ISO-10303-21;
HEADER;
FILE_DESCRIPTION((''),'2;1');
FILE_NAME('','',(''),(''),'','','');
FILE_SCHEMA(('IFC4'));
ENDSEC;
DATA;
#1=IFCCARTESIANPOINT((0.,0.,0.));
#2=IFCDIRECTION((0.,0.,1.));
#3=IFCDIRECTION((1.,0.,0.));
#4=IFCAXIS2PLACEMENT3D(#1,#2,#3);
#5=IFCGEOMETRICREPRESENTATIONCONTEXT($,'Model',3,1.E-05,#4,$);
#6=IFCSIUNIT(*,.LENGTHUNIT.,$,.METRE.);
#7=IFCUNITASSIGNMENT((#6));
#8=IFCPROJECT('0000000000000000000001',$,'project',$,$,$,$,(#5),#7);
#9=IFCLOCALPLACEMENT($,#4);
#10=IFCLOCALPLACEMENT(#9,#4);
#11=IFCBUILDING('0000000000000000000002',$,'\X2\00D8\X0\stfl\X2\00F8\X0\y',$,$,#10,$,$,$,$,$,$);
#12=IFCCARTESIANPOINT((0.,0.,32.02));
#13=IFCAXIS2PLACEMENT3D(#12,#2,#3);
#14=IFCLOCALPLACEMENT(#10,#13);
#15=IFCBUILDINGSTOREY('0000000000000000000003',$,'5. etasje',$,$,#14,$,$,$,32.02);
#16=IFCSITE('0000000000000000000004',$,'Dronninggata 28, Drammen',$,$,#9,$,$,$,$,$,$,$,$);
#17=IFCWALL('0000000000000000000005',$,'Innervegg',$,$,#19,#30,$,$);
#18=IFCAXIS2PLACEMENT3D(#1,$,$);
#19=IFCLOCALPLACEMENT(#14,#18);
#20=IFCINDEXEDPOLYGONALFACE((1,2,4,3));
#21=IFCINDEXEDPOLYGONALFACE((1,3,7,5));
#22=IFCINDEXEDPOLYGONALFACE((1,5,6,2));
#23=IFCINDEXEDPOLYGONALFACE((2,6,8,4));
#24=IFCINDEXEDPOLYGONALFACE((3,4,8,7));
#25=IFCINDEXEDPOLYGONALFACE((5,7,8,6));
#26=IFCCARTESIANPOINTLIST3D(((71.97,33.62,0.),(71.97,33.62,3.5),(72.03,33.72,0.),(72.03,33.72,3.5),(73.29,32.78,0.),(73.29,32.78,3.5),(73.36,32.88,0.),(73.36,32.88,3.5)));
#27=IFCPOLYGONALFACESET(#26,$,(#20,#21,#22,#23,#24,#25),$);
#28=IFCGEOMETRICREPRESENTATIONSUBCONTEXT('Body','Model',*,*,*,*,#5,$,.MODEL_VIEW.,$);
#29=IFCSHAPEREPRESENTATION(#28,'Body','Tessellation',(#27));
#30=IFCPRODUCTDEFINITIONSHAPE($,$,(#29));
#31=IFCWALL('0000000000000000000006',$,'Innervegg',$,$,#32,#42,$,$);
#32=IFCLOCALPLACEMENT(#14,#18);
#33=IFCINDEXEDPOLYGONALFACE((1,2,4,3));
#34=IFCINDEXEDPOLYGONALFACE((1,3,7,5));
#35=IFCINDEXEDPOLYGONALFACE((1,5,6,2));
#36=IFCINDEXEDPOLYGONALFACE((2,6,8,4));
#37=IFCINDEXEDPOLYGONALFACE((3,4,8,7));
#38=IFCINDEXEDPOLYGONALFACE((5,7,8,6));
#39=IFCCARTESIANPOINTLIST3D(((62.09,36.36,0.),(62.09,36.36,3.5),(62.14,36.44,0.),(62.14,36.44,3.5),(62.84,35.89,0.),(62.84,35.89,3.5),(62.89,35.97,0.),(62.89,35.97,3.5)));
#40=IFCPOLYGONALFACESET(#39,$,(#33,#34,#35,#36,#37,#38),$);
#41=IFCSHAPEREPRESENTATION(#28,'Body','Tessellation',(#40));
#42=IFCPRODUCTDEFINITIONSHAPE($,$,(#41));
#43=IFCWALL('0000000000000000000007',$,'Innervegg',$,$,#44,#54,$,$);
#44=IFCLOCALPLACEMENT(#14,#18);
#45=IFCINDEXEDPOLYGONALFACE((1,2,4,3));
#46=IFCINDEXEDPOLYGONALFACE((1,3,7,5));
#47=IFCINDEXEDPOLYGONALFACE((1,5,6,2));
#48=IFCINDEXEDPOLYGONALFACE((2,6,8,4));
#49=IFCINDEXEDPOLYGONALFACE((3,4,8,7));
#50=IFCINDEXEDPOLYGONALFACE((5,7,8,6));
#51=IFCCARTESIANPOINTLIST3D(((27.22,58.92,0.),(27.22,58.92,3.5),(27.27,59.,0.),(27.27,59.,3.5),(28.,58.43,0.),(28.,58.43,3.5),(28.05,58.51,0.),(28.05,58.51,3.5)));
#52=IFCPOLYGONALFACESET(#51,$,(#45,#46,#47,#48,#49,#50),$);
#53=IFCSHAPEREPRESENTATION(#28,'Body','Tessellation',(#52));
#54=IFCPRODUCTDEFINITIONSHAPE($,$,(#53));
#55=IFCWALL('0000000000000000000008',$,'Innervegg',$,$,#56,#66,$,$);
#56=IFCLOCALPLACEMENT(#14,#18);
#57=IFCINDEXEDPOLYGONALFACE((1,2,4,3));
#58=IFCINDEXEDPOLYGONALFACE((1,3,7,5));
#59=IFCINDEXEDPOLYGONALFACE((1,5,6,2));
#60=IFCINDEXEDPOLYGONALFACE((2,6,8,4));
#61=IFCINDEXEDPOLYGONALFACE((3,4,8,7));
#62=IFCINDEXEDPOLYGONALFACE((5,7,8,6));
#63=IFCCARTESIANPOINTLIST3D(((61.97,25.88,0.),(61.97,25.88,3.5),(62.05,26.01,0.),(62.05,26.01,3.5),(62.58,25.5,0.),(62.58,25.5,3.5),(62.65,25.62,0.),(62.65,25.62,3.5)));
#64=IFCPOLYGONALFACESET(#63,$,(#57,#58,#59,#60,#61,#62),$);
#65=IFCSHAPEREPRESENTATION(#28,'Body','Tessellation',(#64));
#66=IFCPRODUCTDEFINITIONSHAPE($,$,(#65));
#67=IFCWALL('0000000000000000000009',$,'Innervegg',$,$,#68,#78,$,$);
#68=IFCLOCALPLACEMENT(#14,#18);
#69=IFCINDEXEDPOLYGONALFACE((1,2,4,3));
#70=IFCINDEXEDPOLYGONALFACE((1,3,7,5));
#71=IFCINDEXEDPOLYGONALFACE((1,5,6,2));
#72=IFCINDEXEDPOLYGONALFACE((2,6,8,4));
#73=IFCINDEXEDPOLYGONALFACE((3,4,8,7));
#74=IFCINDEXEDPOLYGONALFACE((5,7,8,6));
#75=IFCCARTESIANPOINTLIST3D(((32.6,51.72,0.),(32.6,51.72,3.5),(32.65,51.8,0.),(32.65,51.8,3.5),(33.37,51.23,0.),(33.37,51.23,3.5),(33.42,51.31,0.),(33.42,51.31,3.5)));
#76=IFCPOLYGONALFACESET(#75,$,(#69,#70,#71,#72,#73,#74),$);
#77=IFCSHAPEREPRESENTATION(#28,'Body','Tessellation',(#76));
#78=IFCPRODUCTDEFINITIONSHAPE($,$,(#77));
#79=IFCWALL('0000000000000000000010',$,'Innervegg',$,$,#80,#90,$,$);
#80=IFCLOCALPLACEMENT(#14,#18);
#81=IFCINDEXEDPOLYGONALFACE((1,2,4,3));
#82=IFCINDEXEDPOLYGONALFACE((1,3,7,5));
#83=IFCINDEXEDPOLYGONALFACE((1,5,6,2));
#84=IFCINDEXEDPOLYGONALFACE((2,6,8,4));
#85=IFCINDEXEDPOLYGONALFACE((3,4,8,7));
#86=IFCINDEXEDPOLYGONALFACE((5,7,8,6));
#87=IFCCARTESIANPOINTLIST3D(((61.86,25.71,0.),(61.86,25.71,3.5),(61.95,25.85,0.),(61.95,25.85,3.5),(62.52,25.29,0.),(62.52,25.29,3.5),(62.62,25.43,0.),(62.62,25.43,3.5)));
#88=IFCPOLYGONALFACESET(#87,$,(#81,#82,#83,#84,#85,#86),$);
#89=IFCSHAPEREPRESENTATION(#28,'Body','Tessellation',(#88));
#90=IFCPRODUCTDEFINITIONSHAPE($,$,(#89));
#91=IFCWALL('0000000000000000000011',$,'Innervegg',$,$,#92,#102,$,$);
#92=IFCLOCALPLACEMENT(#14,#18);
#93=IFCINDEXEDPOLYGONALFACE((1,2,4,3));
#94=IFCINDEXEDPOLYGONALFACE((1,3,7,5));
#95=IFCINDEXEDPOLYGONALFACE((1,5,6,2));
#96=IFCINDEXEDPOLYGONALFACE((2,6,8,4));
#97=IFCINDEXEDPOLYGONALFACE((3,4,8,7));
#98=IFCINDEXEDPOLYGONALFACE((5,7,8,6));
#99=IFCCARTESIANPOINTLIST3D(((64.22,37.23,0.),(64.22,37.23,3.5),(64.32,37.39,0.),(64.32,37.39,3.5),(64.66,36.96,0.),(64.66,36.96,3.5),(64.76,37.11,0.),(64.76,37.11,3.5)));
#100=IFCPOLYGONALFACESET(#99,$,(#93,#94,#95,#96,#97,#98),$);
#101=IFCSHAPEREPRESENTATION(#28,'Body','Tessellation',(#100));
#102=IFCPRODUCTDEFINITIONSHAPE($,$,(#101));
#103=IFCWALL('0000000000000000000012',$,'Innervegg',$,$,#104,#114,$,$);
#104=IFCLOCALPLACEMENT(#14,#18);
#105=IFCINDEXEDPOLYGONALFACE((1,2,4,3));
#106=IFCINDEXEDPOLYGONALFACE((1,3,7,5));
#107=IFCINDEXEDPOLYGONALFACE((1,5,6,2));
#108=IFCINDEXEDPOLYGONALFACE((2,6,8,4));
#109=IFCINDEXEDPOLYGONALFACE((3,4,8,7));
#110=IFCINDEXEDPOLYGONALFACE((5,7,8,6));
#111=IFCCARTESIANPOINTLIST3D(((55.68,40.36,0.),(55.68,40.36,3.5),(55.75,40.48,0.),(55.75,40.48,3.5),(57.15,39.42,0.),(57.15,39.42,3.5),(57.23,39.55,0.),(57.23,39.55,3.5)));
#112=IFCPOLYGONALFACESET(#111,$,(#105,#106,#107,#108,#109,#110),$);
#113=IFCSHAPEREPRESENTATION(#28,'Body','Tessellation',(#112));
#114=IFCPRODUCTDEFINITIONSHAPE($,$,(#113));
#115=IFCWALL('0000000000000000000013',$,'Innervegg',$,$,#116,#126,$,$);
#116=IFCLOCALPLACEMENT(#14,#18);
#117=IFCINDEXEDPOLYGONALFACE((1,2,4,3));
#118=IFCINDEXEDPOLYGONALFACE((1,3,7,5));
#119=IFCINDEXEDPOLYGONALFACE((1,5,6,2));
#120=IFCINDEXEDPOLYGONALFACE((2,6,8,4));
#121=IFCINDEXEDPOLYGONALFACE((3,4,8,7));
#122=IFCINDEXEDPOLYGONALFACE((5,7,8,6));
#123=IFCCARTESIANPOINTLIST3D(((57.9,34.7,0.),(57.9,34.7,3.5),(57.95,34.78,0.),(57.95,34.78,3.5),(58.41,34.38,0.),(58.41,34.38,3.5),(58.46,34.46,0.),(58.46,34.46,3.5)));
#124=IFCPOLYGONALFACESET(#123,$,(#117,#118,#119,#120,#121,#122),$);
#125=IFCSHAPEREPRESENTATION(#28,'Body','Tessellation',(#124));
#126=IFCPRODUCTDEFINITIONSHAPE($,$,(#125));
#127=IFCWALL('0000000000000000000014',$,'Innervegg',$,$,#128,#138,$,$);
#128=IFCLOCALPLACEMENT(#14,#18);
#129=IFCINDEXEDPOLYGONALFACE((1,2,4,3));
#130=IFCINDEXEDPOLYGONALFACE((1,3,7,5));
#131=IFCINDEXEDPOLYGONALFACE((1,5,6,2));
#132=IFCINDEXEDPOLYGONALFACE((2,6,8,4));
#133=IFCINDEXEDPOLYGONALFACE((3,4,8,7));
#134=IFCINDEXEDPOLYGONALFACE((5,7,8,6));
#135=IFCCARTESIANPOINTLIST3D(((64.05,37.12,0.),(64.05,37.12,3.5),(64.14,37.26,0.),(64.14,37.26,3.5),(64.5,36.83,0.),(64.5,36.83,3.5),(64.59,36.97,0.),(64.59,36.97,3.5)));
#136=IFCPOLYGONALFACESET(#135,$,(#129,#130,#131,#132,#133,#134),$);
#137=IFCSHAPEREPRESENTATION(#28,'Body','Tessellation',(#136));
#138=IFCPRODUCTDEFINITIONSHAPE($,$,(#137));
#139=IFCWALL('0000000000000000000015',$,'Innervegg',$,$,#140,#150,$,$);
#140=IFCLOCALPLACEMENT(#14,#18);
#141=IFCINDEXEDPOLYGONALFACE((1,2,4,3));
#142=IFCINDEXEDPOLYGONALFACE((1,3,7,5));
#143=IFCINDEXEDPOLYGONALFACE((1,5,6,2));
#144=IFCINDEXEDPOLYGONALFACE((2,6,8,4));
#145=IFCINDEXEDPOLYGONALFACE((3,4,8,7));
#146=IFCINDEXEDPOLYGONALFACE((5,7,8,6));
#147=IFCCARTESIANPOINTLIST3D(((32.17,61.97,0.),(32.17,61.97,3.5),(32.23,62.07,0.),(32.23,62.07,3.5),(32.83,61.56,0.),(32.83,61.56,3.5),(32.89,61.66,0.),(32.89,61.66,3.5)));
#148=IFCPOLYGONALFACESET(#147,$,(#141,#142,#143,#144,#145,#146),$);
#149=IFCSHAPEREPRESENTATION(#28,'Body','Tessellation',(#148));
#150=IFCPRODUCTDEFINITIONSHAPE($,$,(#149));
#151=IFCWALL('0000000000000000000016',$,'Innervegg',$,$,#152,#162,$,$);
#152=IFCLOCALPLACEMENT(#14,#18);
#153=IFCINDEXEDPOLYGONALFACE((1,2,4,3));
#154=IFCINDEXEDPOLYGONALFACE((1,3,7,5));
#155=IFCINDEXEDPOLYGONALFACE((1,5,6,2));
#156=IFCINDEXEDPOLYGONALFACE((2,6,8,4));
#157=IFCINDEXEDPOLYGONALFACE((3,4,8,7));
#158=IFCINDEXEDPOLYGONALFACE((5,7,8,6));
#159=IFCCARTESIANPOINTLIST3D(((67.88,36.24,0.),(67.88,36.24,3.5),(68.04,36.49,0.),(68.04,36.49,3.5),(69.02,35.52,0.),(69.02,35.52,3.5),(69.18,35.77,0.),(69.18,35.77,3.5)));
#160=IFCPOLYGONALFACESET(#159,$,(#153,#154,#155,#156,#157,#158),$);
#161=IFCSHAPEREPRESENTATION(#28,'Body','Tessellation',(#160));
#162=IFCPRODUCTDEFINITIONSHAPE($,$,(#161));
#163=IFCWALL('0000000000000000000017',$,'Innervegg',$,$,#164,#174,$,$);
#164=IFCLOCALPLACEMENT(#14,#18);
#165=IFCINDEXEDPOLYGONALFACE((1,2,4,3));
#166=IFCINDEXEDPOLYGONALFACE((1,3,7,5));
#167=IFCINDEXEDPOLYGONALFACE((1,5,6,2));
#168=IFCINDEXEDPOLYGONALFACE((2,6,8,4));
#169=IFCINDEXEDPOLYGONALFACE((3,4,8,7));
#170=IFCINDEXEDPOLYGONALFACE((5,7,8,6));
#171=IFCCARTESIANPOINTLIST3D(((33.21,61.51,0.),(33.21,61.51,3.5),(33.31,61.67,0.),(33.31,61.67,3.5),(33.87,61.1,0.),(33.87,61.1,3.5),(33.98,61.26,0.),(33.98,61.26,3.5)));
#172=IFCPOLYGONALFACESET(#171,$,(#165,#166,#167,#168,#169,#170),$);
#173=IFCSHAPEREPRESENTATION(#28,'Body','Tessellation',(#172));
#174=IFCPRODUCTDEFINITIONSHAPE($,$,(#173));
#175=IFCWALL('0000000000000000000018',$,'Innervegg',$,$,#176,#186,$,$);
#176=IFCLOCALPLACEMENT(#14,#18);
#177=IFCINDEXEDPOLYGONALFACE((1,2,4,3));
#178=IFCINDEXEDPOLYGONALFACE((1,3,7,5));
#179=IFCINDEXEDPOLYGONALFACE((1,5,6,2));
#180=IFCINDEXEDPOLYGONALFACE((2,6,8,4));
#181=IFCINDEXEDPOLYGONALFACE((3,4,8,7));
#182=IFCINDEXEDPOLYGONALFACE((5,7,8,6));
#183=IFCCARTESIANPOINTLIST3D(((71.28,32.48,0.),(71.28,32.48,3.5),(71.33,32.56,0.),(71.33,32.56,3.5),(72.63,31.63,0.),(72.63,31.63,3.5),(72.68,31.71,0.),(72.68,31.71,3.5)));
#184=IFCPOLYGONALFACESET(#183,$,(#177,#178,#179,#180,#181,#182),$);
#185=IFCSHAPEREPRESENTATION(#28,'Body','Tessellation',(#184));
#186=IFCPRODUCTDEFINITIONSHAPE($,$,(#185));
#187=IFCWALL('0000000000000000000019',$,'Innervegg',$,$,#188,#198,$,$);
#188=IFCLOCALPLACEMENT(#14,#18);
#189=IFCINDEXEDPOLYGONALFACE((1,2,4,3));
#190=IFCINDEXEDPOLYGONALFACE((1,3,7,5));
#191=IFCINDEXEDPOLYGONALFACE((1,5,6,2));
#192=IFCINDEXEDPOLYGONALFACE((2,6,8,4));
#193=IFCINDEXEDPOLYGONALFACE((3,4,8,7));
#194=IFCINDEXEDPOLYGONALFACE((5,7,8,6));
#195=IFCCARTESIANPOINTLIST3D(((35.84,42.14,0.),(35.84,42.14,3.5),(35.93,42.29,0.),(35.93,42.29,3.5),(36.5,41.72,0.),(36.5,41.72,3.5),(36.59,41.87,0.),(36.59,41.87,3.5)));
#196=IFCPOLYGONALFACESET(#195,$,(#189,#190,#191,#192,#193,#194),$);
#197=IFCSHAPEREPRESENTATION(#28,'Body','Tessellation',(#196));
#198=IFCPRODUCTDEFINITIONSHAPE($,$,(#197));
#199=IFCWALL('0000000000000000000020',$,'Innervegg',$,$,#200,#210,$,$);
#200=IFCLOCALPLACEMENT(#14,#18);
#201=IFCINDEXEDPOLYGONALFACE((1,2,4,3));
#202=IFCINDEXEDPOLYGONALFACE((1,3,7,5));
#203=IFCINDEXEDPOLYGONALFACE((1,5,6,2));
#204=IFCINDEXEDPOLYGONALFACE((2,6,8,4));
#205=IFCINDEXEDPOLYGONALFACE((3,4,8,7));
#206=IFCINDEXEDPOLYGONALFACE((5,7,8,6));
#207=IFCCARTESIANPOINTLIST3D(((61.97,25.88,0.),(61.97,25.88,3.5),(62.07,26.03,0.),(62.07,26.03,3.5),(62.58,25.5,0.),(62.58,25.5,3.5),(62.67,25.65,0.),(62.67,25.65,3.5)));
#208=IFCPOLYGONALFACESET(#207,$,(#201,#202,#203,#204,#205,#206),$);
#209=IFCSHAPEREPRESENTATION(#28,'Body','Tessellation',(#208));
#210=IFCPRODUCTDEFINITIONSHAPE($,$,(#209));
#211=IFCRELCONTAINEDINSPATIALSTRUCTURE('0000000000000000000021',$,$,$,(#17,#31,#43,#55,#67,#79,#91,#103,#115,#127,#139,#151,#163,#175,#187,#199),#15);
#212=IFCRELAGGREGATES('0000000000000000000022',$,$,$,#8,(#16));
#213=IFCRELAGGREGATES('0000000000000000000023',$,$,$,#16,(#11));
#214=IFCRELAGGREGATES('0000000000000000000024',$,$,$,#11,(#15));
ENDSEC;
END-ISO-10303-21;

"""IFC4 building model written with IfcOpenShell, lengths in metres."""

from ifc_helpers import new_model, si_unit, frame, origin_with_axes, place, context, subcontext, project, spatial, polyline, outline, extrude, element, save


model = new_model("IFC4")

# Units and contexts
model_context = context("Model", 3, precision=1e-05, world=origin_with_axes())
body_context = subcontext(model_context, "Body", "Model", "MODEL_VIEW")
ifc_project = project(units=[si_unit("LENGTHUNIT", "METRE")], contexts=[model_context])

# Site, building, storey
site_placement = place(None, origin_with_axes())
site = spatial("IfcSite", under=ifc_project, at=site_placement, Name="Dronninggata 28, Drammen")
building_placement = place(site_placement, origin_with_axes())
building = spatial("IfcBuilding", under=site, at=building_placement, Name="Østfløy")
storey_placement = place(building_placement, frame((0.0, 0.0, 32.02), z_axis=(0.0, 0.0, 1.0), x_axis=(1.0, 0.0, 0.0)))
storey = spatial("IfcBuildingStorey", under=building, at=storey_placement, Name="5. etasje", Elevation=32.02)

# Walls
wall_1_placement = place(storey_placement, frame((0.0, 0.0, -32.02), z_axis=(0.0, 0.0, 1.0), x_axis=(1.0, 0.0, 0.0)))
element("IfcWall", 1, at=wall_1_placement, inside=storey, Name="Innervegg", context=body_context, shape_type="SweptSolid", body=[
    extrude(outline(polyline([(73.36, 32.88), (73.29, 32.78), (71.97, 33.62), (72.03, 33.72), (73.36, 32.88)])), frame((0.0, 0.0, 32.02)), (0.0, 0.0, 1.0), 3.5),
])
wall_2_placement = place(storey_placement, frame((0.0, 0.0, -32.02), z_axis=(0.0, 0.0, 1.0), x_axis=(1.0, 0.0, 0.0)))
element("IfcWall", 2, at=wall_2_placement, inside=storey, Name="Innervegg", context=body_context, shape_type="SweptSolid", body=[
    extrude(outline(polyline([(62.89, 35.97), (62.84, 35.89), (62.09, 36.36), (62.14, 36.44), (62.89, 35.97)])), frame((0.0, 0.0, 32.02)), (0.0, 0.0, 1.0), 3.5),
])
wall_3_placement = place(storey_placement, frame((0.0, 0.0, -32.02), z_axis=(0.0, 0.0, 1.0), x_axis=(1.0, 0.0, 0.0)))
element("IfcWall", 3, at=wall_3_placement, inside=storey, Name="Innervegg", context=body_context, shape_type="SweptSolid", body=[
    extrude(outline(polyline([(28.05, 58.51), (28.0, 58.43), (27.22, 58.92), (27.27, 59.0), (28.05, 58.51)])), frame((0.0, 0.0, 32.02)), (0.0, 0.0, 1.0), 3.5),
])
wall_4_placement = place(storey_placement, frame((0.0, 0.0, -32.02), z_axis=(0.0, 0.0, 1.0), x_axis=(1.0, 0.0, 0.0)))
element("IfcWall", 4, at=wall_4_placement, inside=storey, Name="Innervegg", context=body_context, shape_type="SweptSolid", body=[
    extrude(outline(polyline([(62.65, 25.62), (62.58, 25.5), (61.97, 25.88), (62.05, 26.01), (62.65, 25.62)])), frame((0.0, 0.0, 32.02)), (0.0, 0.0, 1.0), 3.5),
])
wall_5_placement = place(storey_placement, frame((0.0, 0.0, -32.02), z_axis=(0.0, 0.0, 1.0), x_axis=(1.0, 0.0, 0.0)))
element("IfcWall", 5, at=wall_5_placement, inside=storey, Name="Innervegg", context=body_context, shape_type="SweptSolid", body=[
    extrude(outline(polyline([(33.42, 51.31), (33.37, 51.23), (32.6, 51.72), (32.65, 51.8), (33.42, 51.31)])), frame((0.0, 0.0, 32.02)), (0.0, 0.0, 1.0), 3.5),
])
wall_6_placement = place(storey_placement, frame((0.0, 0.0, -32.02), z_axis=(0.0, 0.0, 1.0), x_axis=(1.0, 0.0, 0.0)))
element("IfcWall", 6, at=wall_6_placement, inside=storey, Name="Innervegg", context=body_context, shape_type="SweptSolid", body=[
    extrude(outline(polyline([(62.62, 25.43), (62.52, 25.29), (61.86, 25.71), (61.95, 25.85), (62.62, 25.43)])), frame((0.0, 0.0, 32.02)), (0.0, 0.0, 1.0), 3.5),
])
wall_7_placement = place(storey_placement, frame((0.0, 0.0, -32.02), z_axis=(0.0, 0.0, 1.0), x_axis=(1.0, 0.0, 0.0)))
element("IfcWall", 7, at=wall_7_placement, inside=storey, Name="Innervegg", context=body_context, shape_type="SweptSolid", body=[
    extrude(outline(polyline([(64.76, 37.11), (64.66, 36.96), (64.22, 37.23), (64.32, 37.39), (64.76, 37.11)])), frame((0.0, 0.0, 32.02)), (0.0, 0.0, 1.0), 3.5),
])
wall_8_placement = place(storey_placement, frame((0.0, 0.0, -32.02), z_axis=(0.0, 0.0, 1.0), x_axis=(1.0, 0.0, 0.0)))
element("IfcWall", 8, at=wall_8_placement, inside=storey, Name="Innervegg", context=body_context, shape_type="SweptSolid", body=[
    extrude(outline(polyline([(57.23, 39.55), (57.15, 39.42), (55.68, 40.36), (55.75, 40.48), (57.23, 39.55)])), frame((0.0, 0.0, 32.02)), (0.0, 0.0, 1.0), 3.5),
])
wall_9_placement = place(storey_placement, frame((0.0, 0.0, -32.02), z_axis=(0.0, 0.0, 1.0), x_axis=(1.0, 0.0, 0.0)))
element("IfcWall", 9, at=wall_9_placement, inside=storey, Name="Innervegg", context=body_context, shape_type="SweptSolid", body=[
    extrude(outline(polyline([(58.46, 34.46), (58.41, 34.38), (57.9, 34.7), (57.95, 34.78), (58.46, 34.46)])), frame((0.0, 0.0, 32.02)), (0.0, 0.0, 1.0), 3.5),
])
wall_10_placement = place(storey_placement, frame((0.0, 0.0, -32.02), z_axis=(0.0, 0.0, 1.0), x_axis=(1.0, 0.0, 0.0)))
element("IfcWall", 10, at=wall_10_placement, inside=storey, Name="Innervegg", context=body_context, shape_type="SweptSolid", body=[
    extrude(outline(polyline([(64.59, 36.97), (64.5, 36.83), (64.05, 37.12), (64.14, 37.26), (64.59, 36.97)])), frame((0.0, 0.0, 32.02)), (0.0, 0.0, 1.0), 3.5),
])
wall_11_placement = place(storey_placement, frame((0.0, 0.0, -32.02), z_axis=(0.0, 0.0, 1.0), x_axis=(1.0, 0.0, 0.0)))
element("IfcWall", 11, at=wall_11_placement, inside=storey, Name="Innervegg", context=body_context, shape_type="SweptSolid", body=[
    extrude(outline(polyline([(32.89, 61.66), (32.83, 61.56), (32.17, 61.97), (32.23, 62.07), (32.89, 61.66)])), frame((0.0, 0.0, 32.02)), (0.0, 0.0, 1.0), 3.5),
])
wall_12_placement = place(storey_placement, frame((0.0, 0.0, -32.02), z_axis=(0.0, 0.0, 1.0), x_axis=(1.0, 0.0, 0.0)))
element("IfcWall", 12, at=wall_12_placement, inside=storey, Name="Innervegg", context=body_context, shape_type="SweptSolid", body=[
    extrude(outline(polyline([(69.18, 35.77), (69.02, 35.52), (67.88, 36.24), (68.04, 36.49), (69.18, 35.77)])), frame((0.0, 0.0, 32.02)), (0.0, 0.0, 1.0), 3.5),
])
wall_13_placement = place(storey_placement, frame((0.0, 0.0, -32.02), z_axis=(0.0, 0.0, 1.0), x_axis=(1.0, 0.0, 0.0)))
element("IfcWall", 13, at=wall_13_placement, inside=storey, Name="Innervegg", context=body_context, shape_type="SweptSolid", body=[
    extrude(outline(polyline([(33.98, 61.26), (33.87, 61.1), (33.21, 61.51), (33.31, 61.67), (33.98, 61.26)])), frame((0.0, 0.0, 32.02)), (0.0, 0.0, 1.0), 3.5),
])
wall_14_placement = place(storey_placement, frame((0.0, 0.0, -32.02), z_axis=(0.0, 0.0, 1.0), x_axis=(1.0, 0.0, 0.0)))
element("IfcWall", 14, at=wall_14_placement, inside=storey, Name="Innervegg", context=body_context, shape_type="SweptSolid", body=[
    extrude(outline(polyline([(72.68, 31.71), (72.63, 31.63), (71.28, 32.48), (71.33, 32.56), (72.68, 31.71)])), frame((0.0, 0.0, 32.02)), (0.0, 0.0, 1.0), 3.5),
])
wall_15_placement = place(storey_placement, frame((0.0, 0.0, -32.02), z_axis=(0.0, 0.0, 1.0), x_axis=(1.0, 0.0, 0.0)))
element("IfcWall", 15, at=wall_15_placement, inside=storey, Name="Innervegg", context=body_context, shape_type="SweptSolid", body=[
    extrude(outline(polyline([(36.59, 41.87), (36.5, 41.72), (35.84, 42.14), (35.93, 42.29), (36.59, 41.87)])), frame((0.0, 0.0, 32.02)), (0.0, 0.0, 1.0), 3.5),
])
wall_16_placement = place(storey_placement, frame((0.0, 0.0, -32.02), z_axis=(0.0, 0.0, 1.0), x_axis=(1.0, 0.0, 0.0)))
element("IfcWall", 16, at=wall_16_placement, inside=storey, Name="Innervegg", context=body_context, shape_type="SweptSolid", body=[
    extrude(outline(polyline([(62.67, 25.65), (62.58, 25.5), (61.97, 25.88), (62.07, 26.03), (62.67, 25.65)])), frame((0.0, 0.0, 32.02)), (0.0, 0.0, 1.0), 3.5),
])

save(model, "model.ifc")
